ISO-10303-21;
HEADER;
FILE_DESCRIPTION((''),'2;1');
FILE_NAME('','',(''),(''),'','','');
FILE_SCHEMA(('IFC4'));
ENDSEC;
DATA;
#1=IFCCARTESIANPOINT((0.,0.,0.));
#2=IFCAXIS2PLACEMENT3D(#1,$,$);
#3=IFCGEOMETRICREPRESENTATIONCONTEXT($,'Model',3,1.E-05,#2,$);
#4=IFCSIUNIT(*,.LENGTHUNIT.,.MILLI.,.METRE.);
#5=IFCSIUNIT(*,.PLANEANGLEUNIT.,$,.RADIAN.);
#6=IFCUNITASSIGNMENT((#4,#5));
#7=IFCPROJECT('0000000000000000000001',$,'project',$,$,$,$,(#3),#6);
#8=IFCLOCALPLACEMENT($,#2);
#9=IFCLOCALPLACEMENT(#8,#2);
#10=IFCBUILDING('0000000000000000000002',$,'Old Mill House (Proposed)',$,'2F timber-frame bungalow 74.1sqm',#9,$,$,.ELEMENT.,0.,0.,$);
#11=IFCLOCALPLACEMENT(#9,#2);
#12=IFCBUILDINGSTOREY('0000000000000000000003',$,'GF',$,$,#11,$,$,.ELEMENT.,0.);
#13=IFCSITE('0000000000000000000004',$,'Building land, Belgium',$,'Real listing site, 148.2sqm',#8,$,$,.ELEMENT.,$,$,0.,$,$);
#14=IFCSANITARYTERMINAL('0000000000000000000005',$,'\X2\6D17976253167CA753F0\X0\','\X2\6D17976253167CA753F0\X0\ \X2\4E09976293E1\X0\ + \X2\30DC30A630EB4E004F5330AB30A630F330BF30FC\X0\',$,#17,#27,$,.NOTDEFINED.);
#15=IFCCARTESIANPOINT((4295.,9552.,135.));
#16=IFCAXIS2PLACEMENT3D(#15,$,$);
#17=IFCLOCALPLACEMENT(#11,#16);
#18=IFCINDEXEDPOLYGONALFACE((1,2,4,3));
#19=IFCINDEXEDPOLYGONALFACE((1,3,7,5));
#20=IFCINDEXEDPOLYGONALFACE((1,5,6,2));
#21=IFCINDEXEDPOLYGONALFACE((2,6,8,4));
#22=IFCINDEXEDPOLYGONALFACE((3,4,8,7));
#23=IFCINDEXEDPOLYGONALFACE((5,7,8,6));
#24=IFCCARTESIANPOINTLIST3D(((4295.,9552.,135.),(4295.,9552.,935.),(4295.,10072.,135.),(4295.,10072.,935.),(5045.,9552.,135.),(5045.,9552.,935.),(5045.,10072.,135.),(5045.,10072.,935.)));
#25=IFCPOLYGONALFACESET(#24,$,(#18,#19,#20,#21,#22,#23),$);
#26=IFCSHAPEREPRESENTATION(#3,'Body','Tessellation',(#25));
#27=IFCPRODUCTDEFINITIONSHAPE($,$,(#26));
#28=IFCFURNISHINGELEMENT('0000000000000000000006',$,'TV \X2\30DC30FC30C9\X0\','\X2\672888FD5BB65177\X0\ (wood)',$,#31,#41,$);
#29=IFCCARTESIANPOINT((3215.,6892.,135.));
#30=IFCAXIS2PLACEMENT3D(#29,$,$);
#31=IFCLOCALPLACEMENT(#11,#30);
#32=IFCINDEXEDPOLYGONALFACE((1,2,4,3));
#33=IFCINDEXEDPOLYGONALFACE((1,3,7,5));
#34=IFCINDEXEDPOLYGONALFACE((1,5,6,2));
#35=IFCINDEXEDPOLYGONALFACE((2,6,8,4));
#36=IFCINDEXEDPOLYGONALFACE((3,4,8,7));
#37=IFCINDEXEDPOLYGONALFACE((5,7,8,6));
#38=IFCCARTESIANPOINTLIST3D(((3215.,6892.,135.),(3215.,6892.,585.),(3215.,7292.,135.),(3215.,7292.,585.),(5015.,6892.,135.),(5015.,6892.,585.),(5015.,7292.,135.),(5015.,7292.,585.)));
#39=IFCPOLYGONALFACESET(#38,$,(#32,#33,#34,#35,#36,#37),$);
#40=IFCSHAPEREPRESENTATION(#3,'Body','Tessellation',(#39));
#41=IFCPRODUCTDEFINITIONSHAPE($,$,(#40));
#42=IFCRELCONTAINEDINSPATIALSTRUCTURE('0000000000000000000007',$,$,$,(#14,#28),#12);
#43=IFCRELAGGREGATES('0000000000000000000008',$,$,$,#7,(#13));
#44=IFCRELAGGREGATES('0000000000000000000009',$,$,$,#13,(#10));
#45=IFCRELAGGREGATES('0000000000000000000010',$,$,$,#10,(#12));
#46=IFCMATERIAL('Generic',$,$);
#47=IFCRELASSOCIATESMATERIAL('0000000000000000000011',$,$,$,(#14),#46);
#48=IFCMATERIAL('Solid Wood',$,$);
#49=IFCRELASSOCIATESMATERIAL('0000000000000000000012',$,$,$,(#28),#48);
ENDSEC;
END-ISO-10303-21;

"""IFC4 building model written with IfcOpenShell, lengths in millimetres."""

from ifc_helpers import new_model, si_unit, frame, frame_2d, origin, place, context, project, spatial, rectangle, extrude, material, element, save


model = new_model("IFC4")

# Units and contexts
model_context = context("Model", 3, precision=1e-05, world=origin())
ifc_project = project(units=[si_unit("LENGTHUNIT", "METRE", prefix="MILLI"), si_unit("PLANEANGLEUNIT", "RADIAN")], contexts=[model_context])

# Site, building, storey
site_placement = place(None, origin())
site = spatial("IfcSite", under=ifc_project, at=site_placement, Name="Building land, Belgium", ObjectType="Real listing site, 148.2sqm", CompositionType="ELEMENT", RefElevation=0.0)
building_placement = place(site_placement, origin())
building = spatial("IfcBuilding", under=site, at=building_placement, Name="Old Mill House (Proposed)", ObjectType="2F timber-frame bungalow 74.1sqm", CompositionType="ELEMENT", ElevationOfRefHeight=0.0, ElevationOfTerrain=0.0)
storey_placement = place(building_placement, origin())
storey = spatial("IfcBuildingStorey", under=building, at=storey_placement, Name="GF", CompositionType="ELEMENT", Elevation=0.0)

# Shared definitions
ifc_material_1 = material(Name="Solid Wood")

# Shared definitions
ifc_material_2 = material(Name="Generic")

# Sanitary terminal
sanitary_terminal_1_placement = place(storey_placement, frame((4295.0, 9552.0, 135.0)))
element("IfcSanitaryTerminal", 1, at=sanitary_terminal_1_placement, inside=storey, material=ifc_material_2, Name="洗面化粧台", Description="洗面化粧台 三面鏡 + ボウル一体カウンター", PredefinedType="NOTDEFINED", context=model_context, shape_type="SweptSolid", body=[
    extrude(rectangle(XDim=750.0, YDim=520.0, at=frame_2d((375.0, 260.0))), frame((4295.0, 9552.0, 135.0)), (0.0, 0.0, 1.0), 800.0),
])

# Furnishing element
furnishing_placement = place(storey_placement, frame((3215.0, 6892.0, 135.0)))
element("IfcFurnishingElement", 2, at=furnishing_placement, inside=storey, material=ifc_material_1, Name="TV ボード", Description="木製家具 (wood)", context=model_context, shape_type="SweptSolid", body=[
    extrude(rectangle(XDim=1800.0, YDim=400.0, at=frame_2d((900.0, 200.0))), frame((3215.0, 6892.0, 135.0)), (0.0, 0.0, 1.0), 450.0),
])

save(model, "model.ifc")
